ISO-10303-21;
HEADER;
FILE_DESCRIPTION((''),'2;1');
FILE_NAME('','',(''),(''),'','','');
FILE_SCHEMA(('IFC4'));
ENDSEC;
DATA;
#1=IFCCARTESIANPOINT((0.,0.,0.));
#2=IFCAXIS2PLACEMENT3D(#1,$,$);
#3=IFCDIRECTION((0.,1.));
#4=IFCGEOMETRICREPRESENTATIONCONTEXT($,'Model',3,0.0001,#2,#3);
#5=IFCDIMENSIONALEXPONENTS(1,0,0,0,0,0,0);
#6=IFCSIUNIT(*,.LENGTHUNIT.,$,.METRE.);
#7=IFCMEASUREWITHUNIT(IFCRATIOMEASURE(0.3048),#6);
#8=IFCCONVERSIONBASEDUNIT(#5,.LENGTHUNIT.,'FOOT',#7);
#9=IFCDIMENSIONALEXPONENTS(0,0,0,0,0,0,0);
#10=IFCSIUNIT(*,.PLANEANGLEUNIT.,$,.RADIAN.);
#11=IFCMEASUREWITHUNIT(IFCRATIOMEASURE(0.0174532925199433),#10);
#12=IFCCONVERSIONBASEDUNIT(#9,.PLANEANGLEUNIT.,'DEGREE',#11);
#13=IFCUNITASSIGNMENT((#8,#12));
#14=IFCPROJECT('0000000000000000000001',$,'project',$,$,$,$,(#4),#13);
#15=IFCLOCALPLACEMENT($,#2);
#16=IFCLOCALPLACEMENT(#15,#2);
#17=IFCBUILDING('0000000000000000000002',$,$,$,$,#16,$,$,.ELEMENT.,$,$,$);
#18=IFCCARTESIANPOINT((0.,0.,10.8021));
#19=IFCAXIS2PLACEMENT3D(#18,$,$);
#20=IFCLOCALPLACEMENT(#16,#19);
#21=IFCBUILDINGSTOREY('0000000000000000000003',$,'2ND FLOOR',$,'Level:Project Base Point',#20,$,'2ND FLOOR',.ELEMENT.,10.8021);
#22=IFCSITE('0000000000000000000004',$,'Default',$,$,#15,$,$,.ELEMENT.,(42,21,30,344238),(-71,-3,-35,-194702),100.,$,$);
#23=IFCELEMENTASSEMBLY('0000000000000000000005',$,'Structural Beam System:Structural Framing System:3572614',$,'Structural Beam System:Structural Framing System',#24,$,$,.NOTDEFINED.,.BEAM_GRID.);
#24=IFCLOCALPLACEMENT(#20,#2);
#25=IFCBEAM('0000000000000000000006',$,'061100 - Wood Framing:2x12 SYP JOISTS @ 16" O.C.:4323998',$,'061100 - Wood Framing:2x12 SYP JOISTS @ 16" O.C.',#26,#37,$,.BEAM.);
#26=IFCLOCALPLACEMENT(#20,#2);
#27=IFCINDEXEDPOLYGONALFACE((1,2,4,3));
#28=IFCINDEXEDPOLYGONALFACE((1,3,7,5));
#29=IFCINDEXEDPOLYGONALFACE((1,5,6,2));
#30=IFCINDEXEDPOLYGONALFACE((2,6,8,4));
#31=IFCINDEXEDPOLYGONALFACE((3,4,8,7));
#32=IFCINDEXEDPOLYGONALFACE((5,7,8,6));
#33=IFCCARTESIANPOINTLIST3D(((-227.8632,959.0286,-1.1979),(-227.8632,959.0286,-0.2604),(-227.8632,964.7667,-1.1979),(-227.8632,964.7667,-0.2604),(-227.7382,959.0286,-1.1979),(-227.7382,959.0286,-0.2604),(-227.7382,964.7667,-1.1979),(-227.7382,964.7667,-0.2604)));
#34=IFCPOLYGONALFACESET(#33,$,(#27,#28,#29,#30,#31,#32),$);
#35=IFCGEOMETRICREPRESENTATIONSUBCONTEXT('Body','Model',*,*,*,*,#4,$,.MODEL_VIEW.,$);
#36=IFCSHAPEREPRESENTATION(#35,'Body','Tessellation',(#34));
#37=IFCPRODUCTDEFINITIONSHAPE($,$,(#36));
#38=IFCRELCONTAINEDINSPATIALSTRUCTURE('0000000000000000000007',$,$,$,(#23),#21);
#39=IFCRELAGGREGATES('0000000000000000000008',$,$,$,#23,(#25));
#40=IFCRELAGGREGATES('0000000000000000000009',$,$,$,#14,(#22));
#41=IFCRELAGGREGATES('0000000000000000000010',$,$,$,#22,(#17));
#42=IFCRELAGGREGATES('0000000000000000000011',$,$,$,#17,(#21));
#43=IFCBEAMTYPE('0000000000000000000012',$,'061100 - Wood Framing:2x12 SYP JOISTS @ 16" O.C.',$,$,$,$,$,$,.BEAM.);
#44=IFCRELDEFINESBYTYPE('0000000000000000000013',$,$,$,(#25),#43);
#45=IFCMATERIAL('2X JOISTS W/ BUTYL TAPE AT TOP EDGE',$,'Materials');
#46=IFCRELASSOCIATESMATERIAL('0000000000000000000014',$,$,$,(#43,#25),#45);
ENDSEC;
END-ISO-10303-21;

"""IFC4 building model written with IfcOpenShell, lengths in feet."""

from ifc_helpers import new_model, entity, si_unit, converted_unit, direction, frame, origin, origin_2d_with_axis, place, context, subcontext, project, spatial, rectangle, extrude, source, transform, mapped, material, material_profile, profile_set, profile_usage, type_object, type_shapes, element, aggregate, save


model = new_model("IFC4")

# Units and contexts
model_context = context("Model", 3, precision=0.0001, world=origin(), true_north=direction((0.0, 1.0)))
body_context = subcontext(model_context, "Body", "Model", "MODEL_VIEW")
ifc_project = project(units=[converted_unit("LENGTHUNIT", "FOOT", entity("IfcRatioMeasure", 0.3048), si_unit("LENGTHUNIT", "METRE"), dimensions=[1, 0, 0, 0, 0, 0, 0]), converted_unit("PLANEANGLEUNIT", "DEGREE", entity("IfcRatioMeasure", 0.0174532925199433), si_unit("PLANEANGLEUNIT", "RADIAN"), dimensions=[0, 0, 0, 0, 0, 0, 0])], contexts=[model_context])

# Site, building, storey
site_placement = place(None, origin())
site = spatial("IfcSite", under=ifc_project, at=site_placement, Name="Default", CompositionType="ELEMENT", RefLatitude=(42, 21, 30, 344238), RefLongitude=(-71, -3, -35, -194702), RefElevation=100.0)
building_placement = place(site_placement, origin())
building = spatial("IfcBuilding", under=site, at=building_placement, CompositionType="ELEMENT")
storey_placement = place(building_placement, frame((0.0, 0.0, 10.8021)))
storey = spatial("IfcBuildingStorey", under=building, at=storey_placement, Name="2ND FLOOR", ObjectType="Level:Project Base Point", LongName="2ND FLOOR", CompositionType="ELEMENT", Elevation=10.8021)

# Element assembly, beam
assembly_1_placement = place(storey_placement, origin())
assembly_1 = element("IfcElementAssembly", 1, at=assembly_1_placement, inside=storey, Name="Structural Beam System:Structural Framing System:3572614", ObjectType="Structural Beam System:Structural Framing System", AssemblyPlace="NOTDEFINED", PredefinedType="BEAM_GRID")
ifc_material_1 = material(Name="2X JOISTS W/ BUTYL TAPE AT TOP EDGE", Category="Materials")
ifc_material_profile_1 = material_profile(ifc_material_1, rectangle(XDim=0.9375, YDim=0.125, at=origin_2d_with_axis()), Name="2x12 SYP JOISTS @ 16\" O.C.")
ifc_profile_set_1 = profile_set([ifc_material_profile_1], Name="2x12 SYP JOISTS @ 16\" O.C.")
ifc_profile_usage_1 = profile_usage(ifc_profile_set_1, cardinal=8)
beam_type_1 = type_object("IfcBeamType", Name="061100 - Wood Framing:2x12 SYP JOISTS @ 16\" O.C.", PredefinedType="BEAM", material=ifc_profile_set_1)
shared_shape_1 = source(origin(), body_context, "Body", "SweptSolid", [
    extrude(rectangle(XDim=0.9375, YDim=0.125, at=origin_2d_with_axis()), frame((-2.869, 0.0, 0.0), z_axis=(1.0, 0.0, 0.0), x_axis=(0.0, 0.0, -1.0)), (0.0, 0.0, 1.0), 5.7381),
])
type_shapes(beam_type_1, [shared_shape_1])
beam_1_placement = place(assembly_1_placement, frame((-227.8007, 961.8977, -0.7292), z_axis=(0.0, 0.0, 1.0), x_axis=(0.0, 1.0, 0.0)))
beam_1 = element("IfcBeam", 2, at=beam_1_placement, type_object=beam_type_1, material=ifc_profile_usage_1, Name="061100 - Wood Framing:2x12 SYP JOISTS @ 16\" O.C.:4323998", ObjectType="061100 - Wood Framing:2x12 SYP JOISTS @ 16\" O.C.", PredefinedType="BEAM", context=body_context, shape_type="MappedRepresentation", body=[
    mapped(shared_shape_1, transform((0.0, 0.0, 0.0), scale=1.0)),
])
aggregate(assembly_1, [beam_1])

save(model, "model.ifc")
